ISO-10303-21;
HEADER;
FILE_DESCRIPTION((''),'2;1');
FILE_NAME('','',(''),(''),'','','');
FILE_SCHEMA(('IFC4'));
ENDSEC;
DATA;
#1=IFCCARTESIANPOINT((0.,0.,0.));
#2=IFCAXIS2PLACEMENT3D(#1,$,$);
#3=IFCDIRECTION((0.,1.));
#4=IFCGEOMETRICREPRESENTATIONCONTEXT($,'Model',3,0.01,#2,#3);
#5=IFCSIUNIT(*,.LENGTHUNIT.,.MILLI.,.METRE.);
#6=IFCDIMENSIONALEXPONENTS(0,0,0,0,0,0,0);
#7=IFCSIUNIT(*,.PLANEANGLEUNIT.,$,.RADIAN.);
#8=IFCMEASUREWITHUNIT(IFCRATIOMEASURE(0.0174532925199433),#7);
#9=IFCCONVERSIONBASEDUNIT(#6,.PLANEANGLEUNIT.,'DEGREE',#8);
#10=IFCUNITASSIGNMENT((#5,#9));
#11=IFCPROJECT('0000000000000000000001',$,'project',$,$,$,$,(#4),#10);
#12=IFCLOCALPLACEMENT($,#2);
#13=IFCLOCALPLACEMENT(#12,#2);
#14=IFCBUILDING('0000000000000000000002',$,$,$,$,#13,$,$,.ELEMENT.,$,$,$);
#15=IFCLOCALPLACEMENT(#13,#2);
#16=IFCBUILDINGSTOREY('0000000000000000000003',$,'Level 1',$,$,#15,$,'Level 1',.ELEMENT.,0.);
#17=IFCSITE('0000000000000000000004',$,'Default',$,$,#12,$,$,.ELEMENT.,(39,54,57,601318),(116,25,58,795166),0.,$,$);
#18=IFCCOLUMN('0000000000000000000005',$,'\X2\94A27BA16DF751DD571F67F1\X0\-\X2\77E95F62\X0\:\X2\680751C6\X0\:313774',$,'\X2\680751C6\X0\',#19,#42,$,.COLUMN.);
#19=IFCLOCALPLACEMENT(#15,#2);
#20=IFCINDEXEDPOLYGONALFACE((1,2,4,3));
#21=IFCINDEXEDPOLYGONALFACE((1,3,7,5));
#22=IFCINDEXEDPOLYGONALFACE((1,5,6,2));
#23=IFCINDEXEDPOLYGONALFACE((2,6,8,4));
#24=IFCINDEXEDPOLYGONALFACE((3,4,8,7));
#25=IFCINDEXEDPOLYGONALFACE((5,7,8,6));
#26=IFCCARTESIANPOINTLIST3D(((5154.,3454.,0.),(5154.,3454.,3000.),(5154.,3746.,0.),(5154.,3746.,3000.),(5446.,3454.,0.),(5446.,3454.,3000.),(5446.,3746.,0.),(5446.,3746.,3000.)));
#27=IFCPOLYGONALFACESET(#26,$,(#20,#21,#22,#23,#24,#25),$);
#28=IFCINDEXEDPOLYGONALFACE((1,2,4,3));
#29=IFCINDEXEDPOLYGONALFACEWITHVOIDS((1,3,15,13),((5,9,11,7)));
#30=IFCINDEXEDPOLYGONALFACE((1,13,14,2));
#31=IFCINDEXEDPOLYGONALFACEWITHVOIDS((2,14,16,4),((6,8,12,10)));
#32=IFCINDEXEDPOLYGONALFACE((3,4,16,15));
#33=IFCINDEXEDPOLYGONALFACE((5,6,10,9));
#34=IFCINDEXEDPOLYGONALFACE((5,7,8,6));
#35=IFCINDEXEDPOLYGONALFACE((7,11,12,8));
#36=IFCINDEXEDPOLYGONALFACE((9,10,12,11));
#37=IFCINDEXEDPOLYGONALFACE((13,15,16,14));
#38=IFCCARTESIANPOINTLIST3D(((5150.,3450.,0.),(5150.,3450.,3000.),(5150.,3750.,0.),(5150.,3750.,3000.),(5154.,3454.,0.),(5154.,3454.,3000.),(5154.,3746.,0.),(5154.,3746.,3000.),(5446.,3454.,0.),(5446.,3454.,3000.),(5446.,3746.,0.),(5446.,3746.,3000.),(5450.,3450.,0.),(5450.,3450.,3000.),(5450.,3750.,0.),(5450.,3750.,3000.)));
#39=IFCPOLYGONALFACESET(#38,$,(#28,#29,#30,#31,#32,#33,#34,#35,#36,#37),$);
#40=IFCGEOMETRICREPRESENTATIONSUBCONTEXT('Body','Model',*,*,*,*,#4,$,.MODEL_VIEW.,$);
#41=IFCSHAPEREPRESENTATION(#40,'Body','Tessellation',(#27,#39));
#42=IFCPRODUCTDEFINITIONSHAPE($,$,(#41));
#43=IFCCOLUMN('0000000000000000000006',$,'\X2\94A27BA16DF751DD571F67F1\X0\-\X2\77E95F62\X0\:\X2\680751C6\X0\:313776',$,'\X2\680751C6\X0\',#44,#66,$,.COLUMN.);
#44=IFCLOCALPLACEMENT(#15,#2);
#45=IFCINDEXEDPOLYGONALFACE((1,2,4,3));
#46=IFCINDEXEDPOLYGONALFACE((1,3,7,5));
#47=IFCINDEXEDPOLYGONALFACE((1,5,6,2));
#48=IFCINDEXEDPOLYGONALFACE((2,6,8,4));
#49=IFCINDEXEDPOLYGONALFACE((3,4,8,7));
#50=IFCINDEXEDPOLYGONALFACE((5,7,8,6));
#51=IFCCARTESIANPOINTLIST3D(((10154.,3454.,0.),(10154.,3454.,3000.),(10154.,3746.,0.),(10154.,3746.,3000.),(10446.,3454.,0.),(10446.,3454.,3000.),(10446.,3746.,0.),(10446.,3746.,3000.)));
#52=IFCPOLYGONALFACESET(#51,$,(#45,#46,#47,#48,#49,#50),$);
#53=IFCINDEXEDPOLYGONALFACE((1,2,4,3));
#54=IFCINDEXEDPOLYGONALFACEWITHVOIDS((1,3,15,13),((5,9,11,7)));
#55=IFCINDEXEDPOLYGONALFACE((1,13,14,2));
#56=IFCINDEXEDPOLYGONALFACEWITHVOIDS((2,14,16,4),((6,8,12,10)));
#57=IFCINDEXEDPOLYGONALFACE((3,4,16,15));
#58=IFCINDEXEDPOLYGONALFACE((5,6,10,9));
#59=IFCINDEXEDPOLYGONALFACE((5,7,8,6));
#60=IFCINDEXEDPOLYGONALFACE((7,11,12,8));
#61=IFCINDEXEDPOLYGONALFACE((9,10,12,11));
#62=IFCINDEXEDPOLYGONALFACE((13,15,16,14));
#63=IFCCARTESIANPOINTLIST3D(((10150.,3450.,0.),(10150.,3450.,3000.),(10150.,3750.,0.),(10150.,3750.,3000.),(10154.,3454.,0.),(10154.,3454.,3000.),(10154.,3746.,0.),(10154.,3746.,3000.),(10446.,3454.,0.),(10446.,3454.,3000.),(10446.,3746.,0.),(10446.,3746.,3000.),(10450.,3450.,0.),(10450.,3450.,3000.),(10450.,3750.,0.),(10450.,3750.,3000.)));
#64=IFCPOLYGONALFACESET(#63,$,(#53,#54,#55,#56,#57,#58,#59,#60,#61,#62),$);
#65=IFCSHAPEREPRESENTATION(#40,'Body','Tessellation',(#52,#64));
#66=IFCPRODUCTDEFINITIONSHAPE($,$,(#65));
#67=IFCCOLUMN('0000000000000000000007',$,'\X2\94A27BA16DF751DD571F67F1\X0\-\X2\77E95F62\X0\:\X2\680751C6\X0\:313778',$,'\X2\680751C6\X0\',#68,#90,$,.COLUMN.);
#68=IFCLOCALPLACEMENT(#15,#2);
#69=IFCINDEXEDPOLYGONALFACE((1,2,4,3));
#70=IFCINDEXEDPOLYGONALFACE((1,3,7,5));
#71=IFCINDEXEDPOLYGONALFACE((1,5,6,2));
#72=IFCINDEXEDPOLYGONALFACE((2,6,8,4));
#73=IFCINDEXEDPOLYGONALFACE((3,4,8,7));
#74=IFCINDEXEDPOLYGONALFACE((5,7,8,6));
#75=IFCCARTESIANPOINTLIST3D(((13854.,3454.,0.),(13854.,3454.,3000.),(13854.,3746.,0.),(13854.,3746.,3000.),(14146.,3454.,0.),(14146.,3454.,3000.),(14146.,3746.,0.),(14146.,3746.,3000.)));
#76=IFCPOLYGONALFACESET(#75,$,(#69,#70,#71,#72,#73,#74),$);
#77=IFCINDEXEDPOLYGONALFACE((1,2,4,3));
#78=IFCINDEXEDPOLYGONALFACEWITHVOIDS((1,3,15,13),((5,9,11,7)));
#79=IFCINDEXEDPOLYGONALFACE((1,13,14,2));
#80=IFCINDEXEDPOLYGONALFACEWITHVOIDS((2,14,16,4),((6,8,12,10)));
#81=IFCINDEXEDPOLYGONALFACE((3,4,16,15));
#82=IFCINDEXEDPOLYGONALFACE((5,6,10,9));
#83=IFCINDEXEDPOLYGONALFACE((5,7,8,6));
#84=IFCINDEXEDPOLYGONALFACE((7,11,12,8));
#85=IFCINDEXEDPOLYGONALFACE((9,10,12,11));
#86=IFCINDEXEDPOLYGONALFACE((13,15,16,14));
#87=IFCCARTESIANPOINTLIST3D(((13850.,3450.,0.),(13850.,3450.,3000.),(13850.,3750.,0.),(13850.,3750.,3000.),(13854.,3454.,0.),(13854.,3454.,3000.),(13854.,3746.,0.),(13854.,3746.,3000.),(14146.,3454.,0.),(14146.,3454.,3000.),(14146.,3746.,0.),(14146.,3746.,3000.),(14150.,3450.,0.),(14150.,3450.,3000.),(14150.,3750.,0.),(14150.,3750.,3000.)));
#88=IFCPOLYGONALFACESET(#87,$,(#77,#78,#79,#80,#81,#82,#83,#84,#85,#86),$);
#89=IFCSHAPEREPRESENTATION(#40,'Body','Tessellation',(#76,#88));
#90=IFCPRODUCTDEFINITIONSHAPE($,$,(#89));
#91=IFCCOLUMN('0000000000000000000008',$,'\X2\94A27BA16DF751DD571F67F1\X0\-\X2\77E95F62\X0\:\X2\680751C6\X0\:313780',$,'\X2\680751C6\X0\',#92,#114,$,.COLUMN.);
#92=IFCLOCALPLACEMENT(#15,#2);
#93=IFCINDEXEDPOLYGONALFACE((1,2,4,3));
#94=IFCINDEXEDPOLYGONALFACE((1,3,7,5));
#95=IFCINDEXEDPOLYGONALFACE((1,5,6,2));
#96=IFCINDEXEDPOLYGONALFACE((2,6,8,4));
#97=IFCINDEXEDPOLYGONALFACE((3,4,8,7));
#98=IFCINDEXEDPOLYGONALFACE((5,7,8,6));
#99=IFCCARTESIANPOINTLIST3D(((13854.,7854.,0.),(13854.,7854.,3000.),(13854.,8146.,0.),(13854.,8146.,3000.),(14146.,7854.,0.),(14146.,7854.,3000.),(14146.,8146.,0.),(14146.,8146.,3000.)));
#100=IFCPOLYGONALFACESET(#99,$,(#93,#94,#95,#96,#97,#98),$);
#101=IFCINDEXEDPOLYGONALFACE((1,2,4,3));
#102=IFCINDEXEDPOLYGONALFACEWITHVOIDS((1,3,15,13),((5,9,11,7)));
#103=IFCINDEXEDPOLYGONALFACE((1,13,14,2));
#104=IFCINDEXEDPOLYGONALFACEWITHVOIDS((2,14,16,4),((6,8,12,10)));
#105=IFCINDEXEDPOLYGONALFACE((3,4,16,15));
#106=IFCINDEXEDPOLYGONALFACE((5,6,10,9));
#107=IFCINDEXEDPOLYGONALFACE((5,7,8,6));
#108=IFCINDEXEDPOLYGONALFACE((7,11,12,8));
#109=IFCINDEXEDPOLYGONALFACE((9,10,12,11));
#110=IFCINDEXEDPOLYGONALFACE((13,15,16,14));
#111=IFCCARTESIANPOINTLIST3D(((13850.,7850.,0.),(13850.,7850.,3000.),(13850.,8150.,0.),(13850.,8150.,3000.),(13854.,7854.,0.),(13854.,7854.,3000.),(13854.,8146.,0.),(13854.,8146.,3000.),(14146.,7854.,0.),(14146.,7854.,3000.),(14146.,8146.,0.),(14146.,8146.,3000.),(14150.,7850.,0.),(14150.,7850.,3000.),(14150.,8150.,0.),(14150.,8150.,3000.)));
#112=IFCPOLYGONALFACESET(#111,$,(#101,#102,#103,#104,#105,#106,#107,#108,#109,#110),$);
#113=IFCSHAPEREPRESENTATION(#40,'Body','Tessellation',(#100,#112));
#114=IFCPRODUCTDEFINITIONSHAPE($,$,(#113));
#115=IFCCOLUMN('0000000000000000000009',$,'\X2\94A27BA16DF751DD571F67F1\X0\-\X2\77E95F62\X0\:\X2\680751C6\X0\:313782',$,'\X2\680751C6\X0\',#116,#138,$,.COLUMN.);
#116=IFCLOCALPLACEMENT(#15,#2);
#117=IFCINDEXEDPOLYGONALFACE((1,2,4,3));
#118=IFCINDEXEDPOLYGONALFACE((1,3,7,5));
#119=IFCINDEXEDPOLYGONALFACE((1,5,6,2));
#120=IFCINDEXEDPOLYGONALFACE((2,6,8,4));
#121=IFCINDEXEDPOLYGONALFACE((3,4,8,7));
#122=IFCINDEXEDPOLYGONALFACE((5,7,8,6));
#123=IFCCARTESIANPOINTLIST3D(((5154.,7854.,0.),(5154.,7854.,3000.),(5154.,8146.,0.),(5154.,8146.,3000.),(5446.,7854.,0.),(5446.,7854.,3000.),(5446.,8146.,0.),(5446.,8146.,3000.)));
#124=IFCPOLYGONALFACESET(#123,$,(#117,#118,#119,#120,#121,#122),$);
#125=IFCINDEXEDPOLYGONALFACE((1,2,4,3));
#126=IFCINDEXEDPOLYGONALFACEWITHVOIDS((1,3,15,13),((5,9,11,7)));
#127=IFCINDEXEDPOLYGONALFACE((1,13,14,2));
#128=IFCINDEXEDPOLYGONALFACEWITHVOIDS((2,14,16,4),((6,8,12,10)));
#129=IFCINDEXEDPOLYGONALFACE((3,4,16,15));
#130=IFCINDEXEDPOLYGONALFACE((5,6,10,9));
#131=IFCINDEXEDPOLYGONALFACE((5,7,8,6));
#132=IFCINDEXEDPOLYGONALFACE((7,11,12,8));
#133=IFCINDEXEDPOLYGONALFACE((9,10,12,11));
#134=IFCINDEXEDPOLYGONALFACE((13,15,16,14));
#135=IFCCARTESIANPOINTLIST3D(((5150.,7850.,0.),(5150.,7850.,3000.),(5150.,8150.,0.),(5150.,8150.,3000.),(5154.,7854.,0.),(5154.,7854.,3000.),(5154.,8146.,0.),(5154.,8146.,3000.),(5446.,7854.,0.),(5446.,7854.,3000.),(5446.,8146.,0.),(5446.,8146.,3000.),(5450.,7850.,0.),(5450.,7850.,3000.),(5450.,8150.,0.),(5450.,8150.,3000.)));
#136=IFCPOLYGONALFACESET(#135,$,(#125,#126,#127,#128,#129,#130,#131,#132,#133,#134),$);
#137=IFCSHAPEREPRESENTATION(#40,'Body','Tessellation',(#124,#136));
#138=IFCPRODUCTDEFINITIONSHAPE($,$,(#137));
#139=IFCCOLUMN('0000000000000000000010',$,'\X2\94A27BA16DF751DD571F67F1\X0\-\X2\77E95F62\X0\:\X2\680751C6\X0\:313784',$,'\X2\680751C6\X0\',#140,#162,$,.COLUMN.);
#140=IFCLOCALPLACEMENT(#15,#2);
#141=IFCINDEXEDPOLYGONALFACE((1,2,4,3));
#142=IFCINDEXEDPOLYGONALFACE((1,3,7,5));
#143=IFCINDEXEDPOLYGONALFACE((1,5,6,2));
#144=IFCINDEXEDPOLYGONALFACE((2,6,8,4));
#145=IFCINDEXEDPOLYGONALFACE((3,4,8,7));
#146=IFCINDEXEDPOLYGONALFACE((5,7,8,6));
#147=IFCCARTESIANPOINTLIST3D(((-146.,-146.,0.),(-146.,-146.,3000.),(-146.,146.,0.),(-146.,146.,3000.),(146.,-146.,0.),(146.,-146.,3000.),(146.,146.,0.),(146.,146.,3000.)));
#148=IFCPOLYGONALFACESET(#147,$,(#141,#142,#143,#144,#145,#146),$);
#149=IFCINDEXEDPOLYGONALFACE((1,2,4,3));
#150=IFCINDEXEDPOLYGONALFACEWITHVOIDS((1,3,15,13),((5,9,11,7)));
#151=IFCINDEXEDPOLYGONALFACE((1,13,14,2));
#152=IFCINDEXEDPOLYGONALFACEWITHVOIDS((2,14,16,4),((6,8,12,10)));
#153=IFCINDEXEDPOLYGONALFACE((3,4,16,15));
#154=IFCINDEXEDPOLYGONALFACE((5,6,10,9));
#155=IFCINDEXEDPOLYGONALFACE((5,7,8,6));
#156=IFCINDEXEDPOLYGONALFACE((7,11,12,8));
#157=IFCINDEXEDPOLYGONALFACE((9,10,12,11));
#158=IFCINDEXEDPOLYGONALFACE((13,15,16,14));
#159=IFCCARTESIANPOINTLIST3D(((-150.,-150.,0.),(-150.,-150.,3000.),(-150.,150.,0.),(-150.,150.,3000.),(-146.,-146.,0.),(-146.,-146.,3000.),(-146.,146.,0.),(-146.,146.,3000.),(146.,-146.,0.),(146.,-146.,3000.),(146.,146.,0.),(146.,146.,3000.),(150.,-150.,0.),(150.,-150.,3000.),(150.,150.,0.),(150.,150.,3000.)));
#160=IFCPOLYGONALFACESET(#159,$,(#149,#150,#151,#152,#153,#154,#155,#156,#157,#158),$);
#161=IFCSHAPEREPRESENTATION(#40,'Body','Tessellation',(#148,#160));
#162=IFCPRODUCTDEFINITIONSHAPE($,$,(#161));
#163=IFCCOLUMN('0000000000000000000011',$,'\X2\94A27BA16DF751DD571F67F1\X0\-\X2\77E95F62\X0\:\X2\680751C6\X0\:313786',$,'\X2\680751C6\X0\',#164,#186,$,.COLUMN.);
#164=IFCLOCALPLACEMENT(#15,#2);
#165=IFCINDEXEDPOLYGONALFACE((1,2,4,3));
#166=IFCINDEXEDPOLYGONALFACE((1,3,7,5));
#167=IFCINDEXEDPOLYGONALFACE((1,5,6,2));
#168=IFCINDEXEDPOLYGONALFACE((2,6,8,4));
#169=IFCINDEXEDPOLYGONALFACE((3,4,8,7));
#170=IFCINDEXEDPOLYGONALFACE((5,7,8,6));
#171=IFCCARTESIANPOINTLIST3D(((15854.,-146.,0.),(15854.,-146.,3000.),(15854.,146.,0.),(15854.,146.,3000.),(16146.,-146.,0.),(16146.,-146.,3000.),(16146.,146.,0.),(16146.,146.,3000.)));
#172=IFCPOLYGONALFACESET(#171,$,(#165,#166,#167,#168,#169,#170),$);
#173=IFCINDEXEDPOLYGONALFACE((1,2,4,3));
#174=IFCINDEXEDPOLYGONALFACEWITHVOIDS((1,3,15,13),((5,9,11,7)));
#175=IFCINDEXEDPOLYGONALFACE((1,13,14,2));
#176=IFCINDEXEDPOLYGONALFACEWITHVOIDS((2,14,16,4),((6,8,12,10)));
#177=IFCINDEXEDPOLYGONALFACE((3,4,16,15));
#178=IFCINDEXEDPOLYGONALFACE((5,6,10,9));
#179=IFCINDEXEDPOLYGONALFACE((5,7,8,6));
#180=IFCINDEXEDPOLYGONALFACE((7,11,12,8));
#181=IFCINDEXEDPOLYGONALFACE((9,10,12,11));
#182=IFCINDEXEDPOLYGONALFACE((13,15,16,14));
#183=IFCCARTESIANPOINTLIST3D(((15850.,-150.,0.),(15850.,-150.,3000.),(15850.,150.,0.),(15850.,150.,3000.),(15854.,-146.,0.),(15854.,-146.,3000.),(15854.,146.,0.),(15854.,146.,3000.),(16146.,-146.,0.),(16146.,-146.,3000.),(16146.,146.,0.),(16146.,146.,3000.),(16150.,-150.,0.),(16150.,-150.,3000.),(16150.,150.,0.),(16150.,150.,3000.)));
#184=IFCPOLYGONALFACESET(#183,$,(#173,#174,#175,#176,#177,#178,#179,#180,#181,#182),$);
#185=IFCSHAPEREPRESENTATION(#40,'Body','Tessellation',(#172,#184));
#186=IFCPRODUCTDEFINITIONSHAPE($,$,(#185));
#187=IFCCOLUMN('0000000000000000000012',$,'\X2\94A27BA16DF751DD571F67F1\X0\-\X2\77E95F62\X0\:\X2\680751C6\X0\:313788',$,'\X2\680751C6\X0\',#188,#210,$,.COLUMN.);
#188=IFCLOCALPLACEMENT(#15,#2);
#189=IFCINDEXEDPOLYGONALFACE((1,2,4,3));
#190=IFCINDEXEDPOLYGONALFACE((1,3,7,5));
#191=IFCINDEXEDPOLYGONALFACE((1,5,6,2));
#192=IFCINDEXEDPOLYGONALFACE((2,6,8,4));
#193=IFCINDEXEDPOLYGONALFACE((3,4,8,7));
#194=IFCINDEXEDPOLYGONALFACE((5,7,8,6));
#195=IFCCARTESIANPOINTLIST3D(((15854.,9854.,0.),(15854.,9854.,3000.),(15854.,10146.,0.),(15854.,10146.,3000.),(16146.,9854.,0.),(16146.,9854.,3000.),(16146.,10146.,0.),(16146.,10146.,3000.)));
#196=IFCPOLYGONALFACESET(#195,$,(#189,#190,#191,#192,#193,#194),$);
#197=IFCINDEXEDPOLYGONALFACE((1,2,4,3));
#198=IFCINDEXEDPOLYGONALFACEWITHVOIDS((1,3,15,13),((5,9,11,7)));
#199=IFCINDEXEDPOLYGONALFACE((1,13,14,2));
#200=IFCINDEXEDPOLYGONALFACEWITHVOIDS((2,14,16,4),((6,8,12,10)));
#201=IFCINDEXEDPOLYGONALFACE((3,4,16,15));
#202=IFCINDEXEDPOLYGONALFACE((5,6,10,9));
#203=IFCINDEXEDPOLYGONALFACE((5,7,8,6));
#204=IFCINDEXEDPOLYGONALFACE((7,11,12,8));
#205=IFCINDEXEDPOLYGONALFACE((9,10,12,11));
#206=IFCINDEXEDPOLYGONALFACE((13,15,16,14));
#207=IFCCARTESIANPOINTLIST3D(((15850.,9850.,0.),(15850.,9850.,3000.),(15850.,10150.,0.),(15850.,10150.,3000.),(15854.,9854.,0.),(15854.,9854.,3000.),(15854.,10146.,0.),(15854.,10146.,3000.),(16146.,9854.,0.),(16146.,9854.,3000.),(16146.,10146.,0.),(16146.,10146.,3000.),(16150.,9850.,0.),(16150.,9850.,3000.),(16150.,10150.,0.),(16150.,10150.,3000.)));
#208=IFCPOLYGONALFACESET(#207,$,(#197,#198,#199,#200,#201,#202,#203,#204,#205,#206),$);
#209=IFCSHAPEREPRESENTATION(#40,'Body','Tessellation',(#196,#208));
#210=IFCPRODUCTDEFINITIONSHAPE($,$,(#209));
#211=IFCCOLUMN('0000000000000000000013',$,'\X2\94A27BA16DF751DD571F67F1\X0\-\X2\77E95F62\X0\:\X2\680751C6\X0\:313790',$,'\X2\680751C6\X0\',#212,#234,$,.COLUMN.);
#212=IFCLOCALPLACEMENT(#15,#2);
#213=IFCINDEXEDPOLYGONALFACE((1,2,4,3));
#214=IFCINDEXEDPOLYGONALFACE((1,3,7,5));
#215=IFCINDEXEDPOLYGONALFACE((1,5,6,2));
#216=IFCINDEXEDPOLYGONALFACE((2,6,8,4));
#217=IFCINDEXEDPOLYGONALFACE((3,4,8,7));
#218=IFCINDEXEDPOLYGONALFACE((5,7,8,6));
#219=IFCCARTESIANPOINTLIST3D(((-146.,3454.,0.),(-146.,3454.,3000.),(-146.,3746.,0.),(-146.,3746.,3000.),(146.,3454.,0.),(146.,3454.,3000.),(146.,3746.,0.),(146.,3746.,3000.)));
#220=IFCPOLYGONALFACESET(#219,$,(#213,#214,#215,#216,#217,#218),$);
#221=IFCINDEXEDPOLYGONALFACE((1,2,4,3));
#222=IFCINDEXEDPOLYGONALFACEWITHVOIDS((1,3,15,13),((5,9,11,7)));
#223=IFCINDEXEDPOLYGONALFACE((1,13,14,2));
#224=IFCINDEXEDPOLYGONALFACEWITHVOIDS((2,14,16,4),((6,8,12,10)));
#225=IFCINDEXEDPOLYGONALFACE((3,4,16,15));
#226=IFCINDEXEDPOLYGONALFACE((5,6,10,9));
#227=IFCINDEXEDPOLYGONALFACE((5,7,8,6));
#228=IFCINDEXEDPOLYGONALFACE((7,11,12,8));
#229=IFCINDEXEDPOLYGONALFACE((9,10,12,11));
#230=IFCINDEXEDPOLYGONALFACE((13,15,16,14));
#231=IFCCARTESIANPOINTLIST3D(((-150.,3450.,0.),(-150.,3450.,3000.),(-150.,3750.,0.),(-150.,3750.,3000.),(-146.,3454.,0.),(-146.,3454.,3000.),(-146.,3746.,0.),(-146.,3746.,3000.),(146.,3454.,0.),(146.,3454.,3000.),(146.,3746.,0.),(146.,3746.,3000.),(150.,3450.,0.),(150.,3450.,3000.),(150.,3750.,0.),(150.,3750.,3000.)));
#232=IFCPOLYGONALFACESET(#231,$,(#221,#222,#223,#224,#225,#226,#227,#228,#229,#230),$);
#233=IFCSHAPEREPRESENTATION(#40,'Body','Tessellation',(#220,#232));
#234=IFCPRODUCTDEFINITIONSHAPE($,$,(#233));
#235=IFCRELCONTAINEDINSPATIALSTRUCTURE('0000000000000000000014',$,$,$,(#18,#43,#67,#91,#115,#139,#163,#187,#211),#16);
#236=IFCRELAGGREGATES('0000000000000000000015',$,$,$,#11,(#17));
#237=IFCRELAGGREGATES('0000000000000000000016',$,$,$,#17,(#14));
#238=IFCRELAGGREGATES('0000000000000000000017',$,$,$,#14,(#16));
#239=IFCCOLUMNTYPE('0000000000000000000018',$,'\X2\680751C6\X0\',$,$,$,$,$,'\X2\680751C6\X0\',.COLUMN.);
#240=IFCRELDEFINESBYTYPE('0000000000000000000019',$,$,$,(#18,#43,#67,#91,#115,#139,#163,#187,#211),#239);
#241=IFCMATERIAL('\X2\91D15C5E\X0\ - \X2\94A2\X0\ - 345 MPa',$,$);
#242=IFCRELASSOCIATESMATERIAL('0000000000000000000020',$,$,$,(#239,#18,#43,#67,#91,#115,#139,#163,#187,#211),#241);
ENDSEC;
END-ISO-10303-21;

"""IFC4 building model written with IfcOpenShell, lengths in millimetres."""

from ifc_helpers import new_model, entity, si_unit, converted_unit, direction, frame, origin, origin_2d_with_axis, place, context, subcontext, project, spatial, polyline, rectangle, outline, extrude, source, transform, mapped, material, type_object, type_shapes, element, save


model = new_model("IFC4")

# Units and contexts
model_context_1 = context("Model", 3, precision=0.01, world=origin(), true_north=direction((0.0, 1.0)))
body_context_1 = subcontext(model_context_1, "Body", "Model", "MODEL_VIEW")
ifc_project = project(units=[si_unit("LENGTHUNIT", "METRE", prefix="MILLI"), converted_unit("PLANEANGLEUNIT", "DEGREE", entity("IfcRatioMeasure", 0.0174532925199433), si_unit("PLANEANGLEUNIT", "RADIAN"), dimensions=[0, 0, 0, 0, 0, 0, 0])], contexts=[model_context_1])

# Site, building, storey
site_placement = place(None, origin())
site = spatial("IfcSite", under=ifc_project, at=site_placement, Name="Default", CompositionType="ELEMENT", RefLatitude=(39, 54, 57, 601318), RefLongitude=(116, 25, 58, 795166), RefElevation=0.0)
building_placement = place(site_placement, origin())
building = spatial("IfcBuilding", under=site, at=building_placement, CompositionType="ELEMENT")
storey_placement = place(building_placement, origin())
storey = spatial("IfcBuildingStorey", under=building, at=storey_placement, Name="Level 1", LongName="Level 1", CompositionType="ELEMENT", Elevation=0.0)

# Columns
ifc_material_1 = material(Name="金属 - 钢 - 345 MPa")
column_type = type_object("IfcColumnType", Name="标准", ElementType="标准", PredefinedType="COLUMN", material=ifc_material_1)
shared_shape = source(origin(), body_context_1, "Body", "SweptSolid", [
    extrude(rectangle(XDim=292.0, YDim=292.0, at=origin_2d_with_axis()), frame((0.0, 0.0, 0.0), z_axis=(0.0, 0.0, 1.0), x_axis=(-1.0, 0.0, 0.0)), (0.0, 0.0, 1.0), 3000.0),
    extrude(outline(polyline([(-150.0, -150.0), (150.0, -150.0), (150.0, 150.0), (-150.0, 150.0), (-150.0, -150.0)]), holes=[polyline([(-146.0, -146.0), (-146.0, 146.0), (146.0, 146.0), (146.0, -146.0), (-146.0, -146.0)])]), frame((0.0, 0.0, 0.0), z_axis=(0.0, 0.0, 1.0), x_axis=(-1.0, 0.0, 0.0)), (0.0, 0.0, 1.0), 3000.0),
])
type_shapes(column_type, [shared_shape])
for number, where, name in (
    (1, (5300.0, 3600.0, 0.0), "钢管混凝土柱-矩形:标准:313774"),
    (2, (10300.0, 3600.0, 0.0), "钢管混凝土柱-矩形:标准:313776"),
    (3, (14000.0, 3600.0, 0.0), "钢管混凝土柱-矩形:标准:313778"),
    (4, (14000.0, 8000.0, 0.0), "钢管混凝土柱-矩形:标准:313780"),
    (5, (5300.0, 8000.0, 0.0), "钢管混凝土柱-矩形:标准:313782"),
    (6, (0.0, 0.0, 0.0), "钢管混凝土柱-矩形:标准:313784"),
    (7, (16000.0, 0.0, 0.0), "钢管混凝土柱-矩形:标准:313786"),
    (8, (16000.0, 10000.0, 0.0), "钢管混凝土柱-矩形:标准:313788"),
    (9, (0.0, 3600.0, 0.0), "钢管混凝土柱-矩形:标准:313790"),
):
    element("IfcColumn", number, at=place(storey_placement, frame(where)), inside=storey, type_object=column_type, material=ifc_material_1, Name=name, ObjectType="标准", PredefinedType="COLUMN", context=body_context_1, shape_type="MappedRepresentation", body=[
        mapped(shared_shape, transform((0.0, 0.0, 0.0), scale=1.0)),
    ])

save(model, "model.ifc")
